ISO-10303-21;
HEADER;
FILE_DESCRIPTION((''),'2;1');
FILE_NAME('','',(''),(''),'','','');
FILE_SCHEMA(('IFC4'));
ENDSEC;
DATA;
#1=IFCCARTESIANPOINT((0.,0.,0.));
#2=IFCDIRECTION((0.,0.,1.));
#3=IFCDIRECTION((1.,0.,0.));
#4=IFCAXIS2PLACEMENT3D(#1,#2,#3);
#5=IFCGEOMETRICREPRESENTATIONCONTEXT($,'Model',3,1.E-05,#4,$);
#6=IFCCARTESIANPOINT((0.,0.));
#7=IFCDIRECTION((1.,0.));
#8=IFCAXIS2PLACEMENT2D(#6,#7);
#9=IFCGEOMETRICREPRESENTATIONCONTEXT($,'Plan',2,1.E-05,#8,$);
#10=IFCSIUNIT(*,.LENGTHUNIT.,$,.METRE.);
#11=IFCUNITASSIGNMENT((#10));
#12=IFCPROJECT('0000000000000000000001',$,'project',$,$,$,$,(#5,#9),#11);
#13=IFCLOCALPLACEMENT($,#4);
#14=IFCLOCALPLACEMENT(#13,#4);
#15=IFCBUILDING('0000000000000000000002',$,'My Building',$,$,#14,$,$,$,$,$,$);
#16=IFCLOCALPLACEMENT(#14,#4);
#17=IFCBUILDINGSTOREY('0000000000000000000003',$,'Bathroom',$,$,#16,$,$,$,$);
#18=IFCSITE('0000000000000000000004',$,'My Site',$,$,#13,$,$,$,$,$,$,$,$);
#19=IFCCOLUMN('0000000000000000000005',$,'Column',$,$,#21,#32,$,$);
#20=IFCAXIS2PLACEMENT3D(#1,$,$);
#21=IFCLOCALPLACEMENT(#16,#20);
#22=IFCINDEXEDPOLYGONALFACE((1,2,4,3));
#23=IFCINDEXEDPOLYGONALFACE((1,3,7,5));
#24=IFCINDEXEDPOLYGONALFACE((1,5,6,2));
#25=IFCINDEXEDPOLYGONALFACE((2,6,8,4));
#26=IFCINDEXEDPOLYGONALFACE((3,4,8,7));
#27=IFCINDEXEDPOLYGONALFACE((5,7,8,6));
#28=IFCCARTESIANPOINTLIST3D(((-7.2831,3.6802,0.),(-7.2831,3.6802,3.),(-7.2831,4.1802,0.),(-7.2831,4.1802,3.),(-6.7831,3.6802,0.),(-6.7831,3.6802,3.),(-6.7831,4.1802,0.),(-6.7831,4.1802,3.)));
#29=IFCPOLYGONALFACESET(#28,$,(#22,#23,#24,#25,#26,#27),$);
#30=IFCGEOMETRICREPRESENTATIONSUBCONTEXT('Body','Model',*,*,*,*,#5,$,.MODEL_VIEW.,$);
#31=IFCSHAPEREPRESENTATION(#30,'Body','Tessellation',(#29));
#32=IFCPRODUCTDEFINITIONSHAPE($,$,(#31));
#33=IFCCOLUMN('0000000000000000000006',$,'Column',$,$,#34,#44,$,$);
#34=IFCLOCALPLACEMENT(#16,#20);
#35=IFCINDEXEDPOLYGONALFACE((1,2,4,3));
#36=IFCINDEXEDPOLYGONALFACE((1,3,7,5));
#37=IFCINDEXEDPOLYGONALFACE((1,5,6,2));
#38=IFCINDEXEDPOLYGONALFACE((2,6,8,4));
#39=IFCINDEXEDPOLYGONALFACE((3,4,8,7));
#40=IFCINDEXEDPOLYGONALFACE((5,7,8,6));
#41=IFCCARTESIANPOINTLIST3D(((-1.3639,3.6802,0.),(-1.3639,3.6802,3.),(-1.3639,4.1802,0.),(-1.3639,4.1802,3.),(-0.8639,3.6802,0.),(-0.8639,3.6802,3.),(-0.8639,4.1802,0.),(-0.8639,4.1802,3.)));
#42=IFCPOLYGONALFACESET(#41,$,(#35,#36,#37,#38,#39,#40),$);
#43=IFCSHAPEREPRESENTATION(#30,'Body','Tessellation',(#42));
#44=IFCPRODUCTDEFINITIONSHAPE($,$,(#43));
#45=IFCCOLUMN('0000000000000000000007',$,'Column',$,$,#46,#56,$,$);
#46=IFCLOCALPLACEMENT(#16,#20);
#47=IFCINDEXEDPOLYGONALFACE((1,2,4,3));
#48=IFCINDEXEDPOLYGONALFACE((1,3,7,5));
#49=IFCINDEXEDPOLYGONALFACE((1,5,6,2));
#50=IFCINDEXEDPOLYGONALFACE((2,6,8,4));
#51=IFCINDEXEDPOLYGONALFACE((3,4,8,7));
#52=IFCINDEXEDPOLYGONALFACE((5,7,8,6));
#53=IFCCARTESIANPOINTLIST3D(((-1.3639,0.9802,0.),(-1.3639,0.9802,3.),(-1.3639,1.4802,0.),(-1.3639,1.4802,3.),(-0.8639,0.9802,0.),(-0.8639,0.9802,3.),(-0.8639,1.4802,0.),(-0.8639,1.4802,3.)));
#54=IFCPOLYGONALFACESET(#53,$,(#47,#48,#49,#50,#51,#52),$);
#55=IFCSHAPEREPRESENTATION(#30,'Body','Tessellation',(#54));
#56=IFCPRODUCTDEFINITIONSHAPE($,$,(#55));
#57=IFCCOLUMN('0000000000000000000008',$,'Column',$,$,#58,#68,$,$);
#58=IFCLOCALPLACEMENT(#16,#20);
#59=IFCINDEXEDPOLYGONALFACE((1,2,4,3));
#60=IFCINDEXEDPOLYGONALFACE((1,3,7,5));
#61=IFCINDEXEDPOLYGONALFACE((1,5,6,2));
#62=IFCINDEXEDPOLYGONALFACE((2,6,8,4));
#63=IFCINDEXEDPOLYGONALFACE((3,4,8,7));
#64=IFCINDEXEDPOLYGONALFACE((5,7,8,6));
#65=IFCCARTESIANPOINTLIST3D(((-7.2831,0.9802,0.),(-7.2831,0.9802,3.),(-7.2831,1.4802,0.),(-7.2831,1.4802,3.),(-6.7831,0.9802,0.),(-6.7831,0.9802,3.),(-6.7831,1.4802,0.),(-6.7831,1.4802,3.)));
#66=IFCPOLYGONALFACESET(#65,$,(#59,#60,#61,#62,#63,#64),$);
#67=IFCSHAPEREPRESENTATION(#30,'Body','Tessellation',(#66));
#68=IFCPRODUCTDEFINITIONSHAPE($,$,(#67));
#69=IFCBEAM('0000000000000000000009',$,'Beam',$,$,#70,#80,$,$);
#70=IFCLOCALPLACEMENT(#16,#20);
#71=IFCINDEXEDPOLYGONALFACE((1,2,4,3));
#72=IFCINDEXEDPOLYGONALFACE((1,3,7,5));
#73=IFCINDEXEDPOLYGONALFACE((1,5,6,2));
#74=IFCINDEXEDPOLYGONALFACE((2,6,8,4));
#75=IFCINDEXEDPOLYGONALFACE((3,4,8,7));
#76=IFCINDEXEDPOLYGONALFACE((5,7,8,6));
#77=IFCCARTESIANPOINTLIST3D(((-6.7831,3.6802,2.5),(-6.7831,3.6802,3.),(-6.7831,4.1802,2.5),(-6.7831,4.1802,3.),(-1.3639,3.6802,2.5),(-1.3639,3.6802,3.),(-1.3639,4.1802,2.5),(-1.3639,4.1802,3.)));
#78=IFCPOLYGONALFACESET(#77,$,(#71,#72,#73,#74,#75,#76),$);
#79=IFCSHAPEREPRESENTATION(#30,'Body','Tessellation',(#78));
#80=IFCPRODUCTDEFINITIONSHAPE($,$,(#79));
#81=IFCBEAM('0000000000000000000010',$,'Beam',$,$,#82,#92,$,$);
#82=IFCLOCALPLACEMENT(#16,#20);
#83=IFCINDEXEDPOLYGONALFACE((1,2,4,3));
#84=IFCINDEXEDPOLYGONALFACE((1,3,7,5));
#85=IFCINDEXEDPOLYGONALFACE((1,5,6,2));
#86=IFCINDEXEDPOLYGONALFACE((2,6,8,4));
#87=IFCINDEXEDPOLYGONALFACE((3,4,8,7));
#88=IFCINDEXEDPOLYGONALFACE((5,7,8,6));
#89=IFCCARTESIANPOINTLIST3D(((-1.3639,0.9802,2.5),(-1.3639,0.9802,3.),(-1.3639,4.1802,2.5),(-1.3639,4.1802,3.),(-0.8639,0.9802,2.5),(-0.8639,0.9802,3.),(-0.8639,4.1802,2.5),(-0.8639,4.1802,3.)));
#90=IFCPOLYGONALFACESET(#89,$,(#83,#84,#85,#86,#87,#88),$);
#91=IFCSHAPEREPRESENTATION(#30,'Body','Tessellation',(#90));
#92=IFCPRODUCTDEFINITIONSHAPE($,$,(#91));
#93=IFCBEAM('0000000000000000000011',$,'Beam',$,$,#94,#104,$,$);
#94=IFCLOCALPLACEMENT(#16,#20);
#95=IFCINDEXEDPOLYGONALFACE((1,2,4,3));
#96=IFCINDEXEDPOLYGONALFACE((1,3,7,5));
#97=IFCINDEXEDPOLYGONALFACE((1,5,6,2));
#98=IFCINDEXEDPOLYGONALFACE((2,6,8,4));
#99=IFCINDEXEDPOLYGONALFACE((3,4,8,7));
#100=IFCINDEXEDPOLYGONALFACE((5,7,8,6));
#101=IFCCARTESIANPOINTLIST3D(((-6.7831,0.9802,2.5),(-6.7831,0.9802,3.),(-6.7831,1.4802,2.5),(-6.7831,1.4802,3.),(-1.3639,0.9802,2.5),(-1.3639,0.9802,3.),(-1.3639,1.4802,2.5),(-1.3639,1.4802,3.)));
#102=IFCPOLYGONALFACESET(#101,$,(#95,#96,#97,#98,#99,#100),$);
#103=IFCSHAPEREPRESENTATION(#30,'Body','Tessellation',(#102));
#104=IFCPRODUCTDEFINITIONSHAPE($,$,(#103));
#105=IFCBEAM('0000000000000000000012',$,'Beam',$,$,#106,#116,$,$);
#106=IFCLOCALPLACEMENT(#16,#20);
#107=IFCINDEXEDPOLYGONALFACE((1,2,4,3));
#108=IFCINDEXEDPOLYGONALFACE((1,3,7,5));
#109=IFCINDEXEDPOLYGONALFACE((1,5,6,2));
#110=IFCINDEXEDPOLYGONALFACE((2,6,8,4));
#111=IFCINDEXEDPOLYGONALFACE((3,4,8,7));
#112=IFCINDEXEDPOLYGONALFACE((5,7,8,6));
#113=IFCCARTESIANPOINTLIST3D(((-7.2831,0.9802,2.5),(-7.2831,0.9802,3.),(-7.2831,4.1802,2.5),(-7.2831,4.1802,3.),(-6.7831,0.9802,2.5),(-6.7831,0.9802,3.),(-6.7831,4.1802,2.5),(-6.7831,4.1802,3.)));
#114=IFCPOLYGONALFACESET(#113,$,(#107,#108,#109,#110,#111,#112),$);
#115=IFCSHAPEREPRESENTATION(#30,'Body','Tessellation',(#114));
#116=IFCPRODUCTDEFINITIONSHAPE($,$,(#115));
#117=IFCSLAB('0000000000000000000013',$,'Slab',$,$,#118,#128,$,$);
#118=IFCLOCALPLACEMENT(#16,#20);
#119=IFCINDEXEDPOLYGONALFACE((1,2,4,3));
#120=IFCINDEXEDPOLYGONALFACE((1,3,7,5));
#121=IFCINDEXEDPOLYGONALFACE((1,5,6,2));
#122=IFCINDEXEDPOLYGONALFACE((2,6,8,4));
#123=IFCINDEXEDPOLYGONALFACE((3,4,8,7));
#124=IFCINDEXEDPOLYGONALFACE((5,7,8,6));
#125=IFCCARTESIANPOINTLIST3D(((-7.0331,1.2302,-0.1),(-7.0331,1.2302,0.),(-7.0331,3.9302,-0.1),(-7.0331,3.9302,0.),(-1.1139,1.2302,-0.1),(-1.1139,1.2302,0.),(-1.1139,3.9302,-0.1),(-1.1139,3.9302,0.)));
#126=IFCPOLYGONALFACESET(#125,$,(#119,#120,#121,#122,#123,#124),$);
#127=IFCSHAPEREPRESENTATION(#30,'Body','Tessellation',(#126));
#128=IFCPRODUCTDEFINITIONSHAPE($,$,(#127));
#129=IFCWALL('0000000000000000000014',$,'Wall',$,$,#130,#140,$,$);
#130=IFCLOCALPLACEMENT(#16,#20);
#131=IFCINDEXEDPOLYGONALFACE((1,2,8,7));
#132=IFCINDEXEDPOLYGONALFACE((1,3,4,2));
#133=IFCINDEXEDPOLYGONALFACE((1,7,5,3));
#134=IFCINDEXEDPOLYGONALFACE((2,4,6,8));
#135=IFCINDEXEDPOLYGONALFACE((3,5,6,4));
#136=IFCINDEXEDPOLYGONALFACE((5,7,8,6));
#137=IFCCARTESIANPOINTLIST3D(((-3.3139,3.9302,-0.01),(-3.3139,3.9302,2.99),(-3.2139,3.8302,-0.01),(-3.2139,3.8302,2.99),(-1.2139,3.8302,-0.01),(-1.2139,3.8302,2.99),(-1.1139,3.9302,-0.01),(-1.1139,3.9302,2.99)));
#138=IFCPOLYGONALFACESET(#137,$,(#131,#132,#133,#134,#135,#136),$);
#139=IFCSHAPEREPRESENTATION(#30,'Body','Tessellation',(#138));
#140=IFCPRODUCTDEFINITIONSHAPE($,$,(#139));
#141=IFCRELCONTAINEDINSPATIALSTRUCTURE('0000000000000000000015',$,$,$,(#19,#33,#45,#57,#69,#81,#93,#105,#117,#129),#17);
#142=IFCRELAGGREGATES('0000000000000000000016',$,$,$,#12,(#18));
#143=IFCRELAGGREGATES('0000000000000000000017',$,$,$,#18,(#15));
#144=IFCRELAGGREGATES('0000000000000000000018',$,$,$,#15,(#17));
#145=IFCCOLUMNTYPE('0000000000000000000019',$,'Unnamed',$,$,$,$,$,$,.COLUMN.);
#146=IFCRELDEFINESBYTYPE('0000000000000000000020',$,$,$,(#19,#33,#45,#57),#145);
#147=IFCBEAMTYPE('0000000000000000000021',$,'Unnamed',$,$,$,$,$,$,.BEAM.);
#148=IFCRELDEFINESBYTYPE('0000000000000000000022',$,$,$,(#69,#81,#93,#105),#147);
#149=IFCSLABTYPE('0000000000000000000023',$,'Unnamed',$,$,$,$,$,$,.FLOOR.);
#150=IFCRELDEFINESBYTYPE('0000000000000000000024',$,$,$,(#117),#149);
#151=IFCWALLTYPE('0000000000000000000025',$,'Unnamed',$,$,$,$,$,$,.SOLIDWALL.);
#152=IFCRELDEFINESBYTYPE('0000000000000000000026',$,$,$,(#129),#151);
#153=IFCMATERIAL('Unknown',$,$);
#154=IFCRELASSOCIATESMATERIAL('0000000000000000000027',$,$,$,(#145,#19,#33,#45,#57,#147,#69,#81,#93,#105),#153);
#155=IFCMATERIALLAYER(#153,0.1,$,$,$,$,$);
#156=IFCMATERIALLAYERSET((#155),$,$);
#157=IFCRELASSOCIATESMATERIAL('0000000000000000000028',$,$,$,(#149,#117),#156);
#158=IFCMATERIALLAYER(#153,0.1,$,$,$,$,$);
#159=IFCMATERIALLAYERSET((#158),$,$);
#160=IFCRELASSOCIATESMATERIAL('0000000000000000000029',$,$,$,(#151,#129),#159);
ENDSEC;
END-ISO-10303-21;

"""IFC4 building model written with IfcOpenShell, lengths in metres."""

from ifc_helpers import new_model, si_unit, frame, origin_with_axes, origin_2d_with_axis, place, context, subcontext, project, spatial, line, indexed_curve, rectangle, outline, extrude, material, layer, layer_set, layer_usage, material_profile, profile_set, profile_usage, type_object, element, save


model = new_model("IFC4")

# Units and contexts
model_context = context("Model", 3, precision=1e-05, world=origin_with_axes())
plan_context = context("Plan", 2, precision=1e-05, world=origin_2d_with_axis())
body_context_1 = subcontext(model_context, "Body", "Model", "MODEL_VIEW")
ifc_project = project(units=[si_unit("LENGTHUNIT", "METRE")], contexts=[model_context, plan_context])

# Site, building, storey
site_placement = place(None, origin_with_axes())
site = spatial("IfcSite", under=ifc_project, at=site_placement, Name="My Site")
building_placement = place(site_placement, origin_with_axes())
building = spatial("IfcBuilding", under=site, at=building_placement, Name="My Building")
storey_placement = place(building_placement, origin_with_axes())
storey = spatial("IfcBuildingStorey", under=building, at=storey_placement, Name="Bathroom")

# Columns
ifc_material = material(Name="Unknown")
ifc_material_profile_1 = material_profile(ifc_material, rectangle(XDim=0.5, YDim=0.5))
ifc_profile_set_1 = profile_set([ifc_material_profile_1])
ifc_profile_usage_1 = profile_usage(ifc_profile_set_1, cardinal=5)
column_type = type_object("IfcColumnType", Name="Unnamed", PredefinedType="COLUMN", material=ifc_profile_set_1)
column_1_placement = place(storey_placement, frame((-7.0331, 3.9302, 0.0), z_axis=(0.0, 0.0, 1.0), x_axis=(1.0, 0.0, 0.0)))
element("IfcColumn", 1, at=column_1_placement, inside=storey, type_object=column_type, material=ifc_profile_usage_1, Name="Column", context=body_context_1, shape_type="SweptSolid", body=[
    extrude(rectangle(XDim=0.5, YDim=0.5), origin_with_axes(), (0.0, 0.0, 1.0), 3.0),
])
ifc_profile_usage_2 = profile_usage(ifc_profile_set_1, cardinal=5)
column_2_placement = place(storey_placement, frame((-1.1139, 3.9302, 0.0), z_axis=(0.0, 0.0, 1.0), x_axis=(1.0, 0.0, 0.0)))
element("IfcColumn", 2, at=column_2_placement, inside=storey, type_object=column_type, material=ifc_profile_usage_2, Name="Column", context=body_context_1, shape_type="SweptSolid", body=[
    extrude(rectangle(XDim=0.5, YDim=0.5), origin_with_axes(), (0.0, 0.0, 1.0), 3.0),
])
ifc_profile_usage_3 = profile_usage(ifc_profile_set_1, cardinal=5)
column_3_placement = place(storey_placement, frame((-1.1139, 1.2302, 0.0), z_axis=(0.0, 0.0, 1.0), x_axis=(1.0, 0.0, 0.0)))
element("IfcColumn", 3, at=column_3_placement, inside=storey, type_object=column_type, material=ifc_profile_usage_3, Name="Column", context=body_context_1, shape_type="SweptSolid", body=[
    extrude(rectangle(XDim=0.5, YDim=0.5), origin_with_axes(), (0.0, 0.0, 1.0), 3.0),
])
ifc_profile_usage_4 = profile_usage(ifc_profile_set_1, cardinal=5)
column_4_placement = place(storey_placement, frame((-7.0331, 1.2302, 0.0), z_axis=(0.0, 0.0, 1.0), x_axis=(1.0, 0.0, 0.0)))
element("IfcColumn", 4, at=column_4_placement, inside=storey, type_object=column_type, material=ifc_profile_usage_4, Name="Column", context=body_context_1, shape_type="SweptSolid", body=[
    extrude(rectangle(XDim=0.5, YDim=0.5), origin_with_axes(), (0.0, 0.0, 1.0), 3.0),
])

# Beams
ifc_material_profile_2 = material_profile(ifc_material, rectangle(XDim=0.5, YDim=0.5))
ifc_profile_set_2 = profile_set([ifc_material_profile_2])
ifc_profile_usage_5 = profile_usage(ifc_profile_set_2, cardinal=5)
beam_type = type_object("IfcBeamType", Name="Unnamed", PredefinedType="BEAM", material=ifc_profile_set_2)
beam_1_placement = place(storey_placement, frame((-6.7831, 3.9302, 2.75), z_axis=(1.0, 0.0, 0.0), x_axis=(0.0, 1.0, 0.0)))
element("IfcBeam", 5, at=beam_1_placement, inside=storey, type_object=beam_type, material=ifc_profile_usage_5, Name="Beam", context=body_context_1, shape_type="SweptSolid", body=[
    extrude(rectangle(XDim=0.5, YDim=0.5), origin_with_axes(), (0.0, 0.0, 1.0), 5.4192),
])
ifc_profile_usage_6 = profile_usage(ifc_profile_set_2, cardinal=5)
beam_2_placement = place(storey_placement, frame((-1.1139, 4.1802, 2.75), z_axis=(0.0, -1.0, 0.0), x_axis=(1.0, 0.0, 0.0)))
element("IfcBeam", 6, at=beam_2_placement, inside=storey, type_object=beam_type, material=ifc_profile_usage_6, Name="Beam", context=body_context_1, shape_type="SweptSolid", body=[
    extrude(rectangle(XDim=0.5, YDim=0.5), origin_with_axes(), (0.0, 0.0, 1.0), 3.2),
])
ifc_profile_usage_7 = profile_usage(ifc_profile_set_2, cardinal=5)
beam_3_placement = place(storey_placement, frame((-1.3639, 1.2302, 2.75), z_axis=(-1.0, 0.0, 0.0), x_axis=(0.0, -1.0, 0.0)))
element("IfcBeam", 7, at=beam_3_placement, inside=storey, type_object=beam_type, material=ifc_profile_usage_7, Name="Beam", context=body_context_1, shape_type="SweptSolid", body=[
    extrude(rectangle(XDim=0.5, YDim=0.5), origin_with_axes(), (0.0, 0.0, 1.0), 5.4192),
])
ifc_profile_usage_8 = profile_usage(ifc_profile_set_2, cardinal=5)
beam_4_placement = place(storey_placement, frame((-7.0331, 0.9802, 2.75), z_axis=(0.0, 1.0, 0.0), x_axis=(-1.0, 0.0, 0.0)))
element("IfcBeam", 8, at=beam_4_placement, inside=storey, type_object=beam_type, material=ifc_profile_usage_8, Name="Beam", context=body_context_1, shape_type="SweptSolid", body=[
    extrude(rectangle(XDim=0.5, YDim=0.5), origin_with_axes(), (0.0, 0.0, 1.0), 3.2),
])

# Slab
ifc_layer_1 = layer(ifc_material, 0.1)
ifc_layer_set_1 = layer_set([ifc_layer_1])
ifc_layer_usage_1 = layer_usage(ifc_layer_set_1, "AXIS3", "POSITIVE", -0.1)
slab_type = type_object("IfcSlabType", Name="Unnamed", PredefinedType="FLOOR", material=ifc_layer_set_1)
slab_placement = place(storey_placement, frame((-7.0331, 3.9302, 0.0), z_axis=(0.0, 0.0, 1.0), x_axis=(1.0, 0.0, 0.0)))
element("IfcSlab", 9, at=slab_placement, inside=storey, type_object=slab_type, material=ifc_layer_usage_1, Name="Slab", context=body_context_1, shape_type="SweptSolid", body=[
    extrude(outline(indexed_curve([(0.0, 0.0), (5.9192, 0.0), (5.9192, -2.7), (0.0, -2.7), (0.0, 0.0), (0.0, 0.0)])), frame((0.0, 0.0, -0.1), z_axis=(0.0, 0.0, 1.0), x_axis=(1.0, 0.0, 0.0)), (0.0, 0.0, 1.0), 0.1),
])

# Wall
ifc_layer_2 = layer(ifc_material, 0.1)
ifc_layer_set_2 = layer_set([ifc_layer_2])
ifc_layer_usage_2 = layer_usage(ifc_layer_set_2, "AXIS2", "POSITIVE", 0.0)
wall_type = type_object("IfcWallType", Name="Unnamed", PredefinedType="SOLIDWALL", material=ifc_layer_set_2)
wall_1_placement = place(storey_placement, frame((-3.2139, 3.8302, -0.01), z_axis=(0.0, 0.0, 1.0), x_axis=(1.0, 0.0, 0.0)))
element("IfcWall", 10, at=wall_1_placement, inside=storey, type_object=wall_type, material=ifc_layer_usage_2, Name="Wall", context=body_context_1, shape_type="SweptSolid", body=[
    extrude(outline(indexed_curve([(0.0, 0.0), (-0.1, 0.1), (2.1, 0.1), (2.0, 0.0)], segments=[line(1, 2, 3, 4, 1)])), origin_with_axes(), (0.0, 0.0, 1.0), 3.0),
])

save(model, "model.ifc")
